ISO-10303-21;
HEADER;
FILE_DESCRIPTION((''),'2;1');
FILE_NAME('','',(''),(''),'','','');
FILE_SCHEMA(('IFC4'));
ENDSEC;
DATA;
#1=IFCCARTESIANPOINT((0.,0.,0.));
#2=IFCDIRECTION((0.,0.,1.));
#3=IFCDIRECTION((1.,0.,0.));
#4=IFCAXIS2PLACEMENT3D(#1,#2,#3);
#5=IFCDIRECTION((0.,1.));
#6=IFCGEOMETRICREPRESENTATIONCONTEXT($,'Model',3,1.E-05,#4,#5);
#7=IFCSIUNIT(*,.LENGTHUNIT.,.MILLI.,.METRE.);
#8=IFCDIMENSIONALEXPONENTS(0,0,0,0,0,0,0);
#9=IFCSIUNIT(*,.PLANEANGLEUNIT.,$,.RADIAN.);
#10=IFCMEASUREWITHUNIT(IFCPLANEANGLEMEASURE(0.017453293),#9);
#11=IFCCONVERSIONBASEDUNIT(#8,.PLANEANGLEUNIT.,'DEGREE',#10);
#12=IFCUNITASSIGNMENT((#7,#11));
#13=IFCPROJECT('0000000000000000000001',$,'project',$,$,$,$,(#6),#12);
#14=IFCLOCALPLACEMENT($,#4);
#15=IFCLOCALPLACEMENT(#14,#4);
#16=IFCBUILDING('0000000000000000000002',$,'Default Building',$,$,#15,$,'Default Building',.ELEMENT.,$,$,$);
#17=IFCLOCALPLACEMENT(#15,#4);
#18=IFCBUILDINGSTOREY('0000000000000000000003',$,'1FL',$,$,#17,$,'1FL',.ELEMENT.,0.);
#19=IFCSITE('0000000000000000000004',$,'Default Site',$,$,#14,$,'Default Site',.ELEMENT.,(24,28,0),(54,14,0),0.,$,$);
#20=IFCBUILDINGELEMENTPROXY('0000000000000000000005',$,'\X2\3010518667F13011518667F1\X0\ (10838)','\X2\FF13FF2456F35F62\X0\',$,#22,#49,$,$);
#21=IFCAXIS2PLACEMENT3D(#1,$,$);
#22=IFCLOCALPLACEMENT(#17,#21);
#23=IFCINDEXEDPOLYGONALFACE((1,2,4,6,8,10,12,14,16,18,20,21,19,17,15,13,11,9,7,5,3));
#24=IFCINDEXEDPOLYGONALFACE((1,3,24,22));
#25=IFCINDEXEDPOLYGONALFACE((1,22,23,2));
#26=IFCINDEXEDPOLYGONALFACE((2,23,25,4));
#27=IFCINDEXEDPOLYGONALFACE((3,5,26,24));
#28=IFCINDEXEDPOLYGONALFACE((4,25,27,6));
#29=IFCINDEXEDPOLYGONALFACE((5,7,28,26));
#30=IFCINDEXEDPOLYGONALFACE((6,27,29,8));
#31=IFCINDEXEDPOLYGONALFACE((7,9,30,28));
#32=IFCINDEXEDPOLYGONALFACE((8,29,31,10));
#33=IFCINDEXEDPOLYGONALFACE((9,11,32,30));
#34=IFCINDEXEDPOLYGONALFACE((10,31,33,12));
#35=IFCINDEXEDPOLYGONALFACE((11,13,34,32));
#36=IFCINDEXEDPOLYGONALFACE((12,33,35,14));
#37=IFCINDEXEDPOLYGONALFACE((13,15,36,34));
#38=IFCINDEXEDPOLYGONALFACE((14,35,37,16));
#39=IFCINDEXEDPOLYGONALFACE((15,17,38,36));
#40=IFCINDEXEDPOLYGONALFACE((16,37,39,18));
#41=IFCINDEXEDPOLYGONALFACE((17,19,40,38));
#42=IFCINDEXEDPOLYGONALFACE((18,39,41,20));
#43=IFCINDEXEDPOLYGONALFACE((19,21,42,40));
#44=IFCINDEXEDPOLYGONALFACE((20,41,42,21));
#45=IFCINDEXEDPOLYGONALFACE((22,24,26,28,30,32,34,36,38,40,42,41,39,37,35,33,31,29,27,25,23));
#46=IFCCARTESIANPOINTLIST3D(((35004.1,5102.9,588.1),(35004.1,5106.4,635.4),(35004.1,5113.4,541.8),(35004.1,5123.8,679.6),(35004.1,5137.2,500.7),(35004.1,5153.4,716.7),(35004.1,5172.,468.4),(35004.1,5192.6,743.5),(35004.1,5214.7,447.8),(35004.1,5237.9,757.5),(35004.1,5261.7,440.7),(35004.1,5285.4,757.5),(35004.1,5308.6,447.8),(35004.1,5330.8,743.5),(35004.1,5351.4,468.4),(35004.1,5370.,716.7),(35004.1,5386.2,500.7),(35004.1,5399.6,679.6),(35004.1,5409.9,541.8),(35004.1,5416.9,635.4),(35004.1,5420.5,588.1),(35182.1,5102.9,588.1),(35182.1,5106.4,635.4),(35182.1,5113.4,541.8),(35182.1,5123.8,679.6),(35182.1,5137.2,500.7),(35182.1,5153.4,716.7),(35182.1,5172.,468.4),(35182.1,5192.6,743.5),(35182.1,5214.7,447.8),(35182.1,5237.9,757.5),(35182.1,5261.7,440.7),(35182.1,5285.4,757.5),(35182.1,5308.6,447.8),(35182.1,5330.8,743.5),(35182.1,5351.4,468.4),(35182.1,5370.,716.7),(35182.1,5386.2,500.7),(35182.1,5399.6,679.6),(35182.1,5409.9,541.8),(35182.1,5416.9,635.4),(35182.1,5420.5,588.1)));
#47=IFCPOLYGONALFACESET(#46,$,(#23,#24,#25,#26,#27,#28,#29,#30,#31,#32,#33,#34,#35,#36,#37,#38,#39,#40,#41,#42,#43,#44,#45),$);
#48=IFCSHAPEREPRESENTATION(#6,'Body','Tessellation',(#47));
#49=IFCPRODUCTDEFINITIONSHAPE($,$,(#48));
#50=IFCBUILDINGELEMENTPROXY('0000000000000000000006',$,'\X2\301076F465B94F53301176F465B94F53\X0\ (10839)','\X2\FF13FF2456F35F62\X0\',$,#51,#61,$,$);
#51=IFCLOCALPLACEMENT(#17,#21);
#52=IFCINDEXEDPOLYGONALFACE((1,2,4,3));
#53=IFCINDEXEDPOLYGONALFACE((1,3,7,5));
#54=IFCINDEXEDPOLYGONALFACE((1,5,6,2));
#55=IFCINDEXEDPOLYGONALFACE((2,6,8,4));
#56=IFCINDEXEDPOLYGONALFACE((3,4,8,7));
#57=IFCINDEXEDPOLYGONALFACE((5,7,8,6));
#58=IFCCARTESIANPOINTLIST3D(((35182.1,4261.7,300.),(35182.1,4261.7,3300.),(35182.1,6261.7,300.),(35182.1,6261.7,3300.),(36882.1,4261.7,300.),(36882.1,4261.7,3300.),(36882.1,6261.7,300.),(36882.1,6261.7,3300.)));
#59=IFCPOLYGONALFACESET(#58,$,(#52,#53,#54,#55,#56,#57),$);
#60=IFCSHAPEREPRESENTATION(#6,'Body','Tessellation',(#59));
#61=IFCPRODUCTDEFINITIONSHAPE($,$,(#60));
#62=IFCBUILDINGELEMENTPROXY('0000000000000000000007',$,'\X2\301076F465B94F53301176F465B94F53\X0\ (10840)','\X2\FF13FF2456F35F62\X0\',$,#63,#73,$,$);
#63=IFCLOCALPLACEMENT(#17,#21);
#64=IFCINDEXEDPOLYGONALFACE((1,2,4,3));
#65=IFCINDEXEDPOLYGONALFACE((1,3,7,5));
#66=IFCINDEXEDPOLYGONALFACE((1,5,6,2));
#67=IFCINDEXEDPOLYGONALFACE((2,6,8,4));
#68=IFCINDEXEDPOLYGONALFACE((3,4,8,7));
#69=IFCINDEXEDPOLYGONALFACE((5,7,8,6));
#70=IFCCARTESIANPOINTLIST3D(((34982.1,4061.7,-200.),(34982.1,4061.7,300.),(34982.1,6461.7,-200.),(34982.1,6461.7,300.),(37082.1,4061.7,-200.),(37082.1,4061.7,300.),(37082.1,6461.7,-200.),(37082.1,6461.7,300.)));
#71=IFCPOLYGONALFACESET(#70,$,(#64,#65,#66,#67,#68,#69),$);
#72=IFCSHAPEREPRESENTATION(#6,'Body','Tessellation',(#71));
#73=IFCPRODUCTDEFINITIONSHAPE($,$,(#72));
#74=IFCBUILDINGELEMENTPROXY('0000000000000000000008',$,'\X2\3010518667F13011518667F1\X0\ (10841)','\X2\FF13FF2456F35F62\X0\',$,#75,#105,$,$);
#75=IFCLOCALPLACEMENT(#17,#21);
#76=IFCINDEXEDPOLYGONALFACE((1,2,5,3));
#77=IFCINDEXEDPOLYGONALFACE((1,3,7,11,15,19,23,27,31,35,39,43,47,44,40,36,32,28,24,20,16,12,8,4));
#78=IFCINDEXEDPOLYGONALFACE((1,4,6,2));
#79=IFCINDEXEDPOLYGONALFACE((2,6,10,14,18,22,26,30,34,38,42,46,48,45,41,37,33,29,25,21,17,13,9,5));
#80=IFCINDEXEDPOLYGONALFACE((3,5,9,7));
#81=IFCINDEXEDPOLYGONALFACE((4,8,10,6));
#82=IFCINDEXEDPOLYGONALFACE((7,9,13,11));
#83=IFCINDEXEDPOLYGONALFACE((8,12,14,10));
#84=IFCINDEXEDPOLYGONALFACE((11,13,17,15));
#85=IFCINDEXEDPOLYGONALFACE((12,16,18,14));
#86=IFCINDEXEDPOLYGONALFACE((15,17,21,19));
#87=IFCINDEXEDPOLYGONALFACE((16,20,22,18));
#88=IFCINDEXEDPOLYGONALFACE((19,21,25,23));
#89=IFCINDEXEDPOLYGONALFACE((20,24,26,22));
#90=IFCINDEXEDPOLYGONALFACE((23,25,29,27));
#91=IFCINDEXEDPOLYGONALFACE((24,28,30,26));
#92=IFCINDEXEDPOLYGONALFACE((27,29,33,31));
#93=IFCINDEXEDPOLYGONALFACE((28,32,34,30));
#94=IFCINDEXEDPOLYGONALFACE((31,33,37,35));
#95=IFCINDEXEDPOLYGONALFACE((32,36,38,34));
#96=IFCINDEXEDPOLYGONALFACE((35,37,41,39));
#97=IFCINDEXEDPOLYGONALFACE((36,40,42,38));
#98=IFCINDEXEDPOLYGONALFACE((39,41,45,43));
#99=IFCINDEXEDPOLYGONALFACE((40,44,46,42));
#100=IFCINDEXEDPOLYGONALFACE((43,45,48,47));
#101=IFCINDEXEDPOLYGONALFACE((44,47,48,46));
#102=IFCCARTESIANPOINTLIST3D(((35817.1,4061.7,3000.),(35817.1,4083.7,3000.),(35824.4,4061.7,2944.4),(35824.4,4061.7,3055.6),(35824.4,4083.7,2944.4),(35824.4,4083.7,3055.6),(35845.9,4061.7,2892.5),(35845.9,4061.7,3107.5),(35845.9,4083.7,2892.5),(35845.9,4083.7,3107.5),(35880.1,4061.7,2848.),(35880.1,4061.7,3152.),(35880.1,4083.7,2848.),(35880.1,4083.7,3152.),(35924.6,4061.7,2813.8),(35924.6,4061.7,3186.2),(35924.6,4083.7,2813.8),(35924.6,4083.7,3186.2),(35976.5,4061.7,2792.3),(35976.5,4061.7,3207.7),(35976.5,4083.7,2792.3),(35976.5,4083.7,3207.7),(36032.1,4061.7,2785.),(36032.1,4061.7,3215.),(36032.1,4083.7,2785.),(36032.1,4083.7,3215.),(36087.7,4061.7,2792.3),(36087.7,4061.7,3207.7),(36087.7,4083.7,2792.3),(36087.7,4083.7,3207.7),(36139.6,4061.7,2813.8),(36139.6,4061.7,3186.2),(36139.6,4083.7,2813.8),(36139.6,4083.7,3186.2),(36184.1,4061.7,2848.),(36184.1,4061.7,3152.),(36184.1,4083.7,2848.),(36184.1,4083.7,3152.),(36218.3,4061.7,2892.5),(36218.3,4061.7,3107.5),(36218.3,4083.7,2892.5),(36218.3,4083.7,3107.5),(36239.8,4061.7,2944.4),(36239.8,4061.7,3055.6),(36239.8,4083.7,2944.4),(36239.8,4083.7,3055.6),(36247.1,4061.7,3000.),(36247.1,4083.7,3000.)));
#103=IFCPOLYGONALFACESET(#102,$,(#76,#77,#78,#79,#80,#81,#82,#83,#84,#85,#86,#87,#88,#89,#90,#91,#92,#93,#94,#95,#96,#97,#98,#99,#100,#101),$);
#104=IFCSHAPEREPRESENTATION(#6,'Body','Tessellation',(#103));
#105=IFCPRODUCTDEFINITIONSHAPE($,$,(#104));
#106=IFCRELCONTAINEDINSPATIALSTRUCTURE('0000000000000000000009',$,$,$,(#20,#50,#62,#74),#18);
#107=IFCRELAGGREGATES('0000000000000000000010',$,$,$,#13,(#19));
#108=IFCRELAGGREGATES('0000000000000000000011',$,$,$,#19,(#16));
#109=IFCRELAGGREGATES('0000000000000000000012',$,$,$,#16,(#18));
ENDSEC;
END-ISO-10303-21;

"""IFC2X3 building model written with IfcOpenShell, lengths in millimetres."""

from ifc_helpers import new_model, entity, si_unit, converted_unit, direction, frame, origin_with_axes, origin_2d_with_axis, place, context, project, spatial, rectangle, circle, extrude, source, transform, mapped, element, save


model = new_model("IFC2X3")

# Units and contexts
model_context = context("Model", 3, precision=1e-05, world=origin_with_axes(), true_north=direction((0.0, 1.0)))
ifc_project = project(units=[si_unit("LENGTHUNIT", "METRE", prefix="MILLI"), converted_unit("PLANEANGLEUNIT", "DEGREE", entity("IfcPlaneAngleMeasure", 0.017453293), si_unit("PLANEANGLEUNIT", "RADIAN"), dimensions=[0, 0, 0, 0, 0, 0, 0])], contexts=[model_context])

# Site, building, storey
site_placement = place(None, origin_with_axes())
site = spatial("IfcSite", under=ifc_project, at=site_placement, Name="Default Site", LongName="Default Site", CompositionType="ELEMENT", RefLatitude=(24, 28, 0), RefLongitude=(54, 14, 0), RefElevation=0.0)
building_placement = place(site_placement, origin_with_axes())
building = spatial("IfcBuilding", under=site, at=building_placement, Name="Default Building", LongName="Default Building", CompositionType="ELEMENT")
storey_placement = place(building_placement, origin_with_axes())
storey = spatial("IfcBuildingStorey", under=building, at=storey_placement, Name="1FL", LongName="1FL", CompositionType="ELEMENT", Elevation=0.0)

# Building element proxies
shared_shape_1 = source(origin_with_axes(), model_context, "Body", "SweptSolid", [
    extrude(circle(Radius=159.2, at=origin_2d_with_axis()), frame((0.0, 0.0, 0.0), z_axis=(0.0, 0.0, 1.0), x_axis=(1.0, 0.0, 0.0)), (0.0, 0.0, 1.0), 178.0),
])
proxy_1_placement = place(storey_placement, frame((35182.1, 5261.7, 600.0), z_axis=(-1.0, 0.0, 0.0), x_axis=(0.0, 0.0, -1.0)))
element("IfcBuildingElementProxy", 1, at=proxy_1_placement, inside=storey, Name="【円柱】円柱 (10838)", Description="３Ｄ図形", context=model_context, shape_type="MappedRepresentation", body=[
    mapped(shared_shape_1, transform((0.0, 0.0, 0.0))),
])
shared_shape_2 = source(origin_with_axes(), model_context, "Body", "SweptSolid", [
    extrude(rectangle(XDim=2000.0, YDim=1700.0, at=origin_2d_with_axis()), frame((0.0, 0.0, 0.0), z_axis=(0.0, 0.0, 1.0), x_axis=(1.0, 0.0, 0.0)), (0.0, 0.0, 1.0), 3000.0),
])
proxy_2_placement = place(storey_placement, frame((36032.1, 5261.7, 300.0), z_axis=(0.0, 0.0, 1.0), x_axis=(0.0, 1.0, 0.0)))
element("IfcBuildingElementProxy", 2, at=proxy_2_placement, inside=storey, Name="【直方体】直方体 (10839)", Description="３Ｄ図形", context=model_context, shape_type="MappedRepresentation", body=[
    mapped(shared_shape_2, transform((0.0, 0.0, 0.0))),
])
shared_shape_3 = source(origin_with_axes(), model_context, "Body", "SweptSolid", [
    extrude(rectangle(XDim=2400.0, YDim=2100.0, at=origin_2d_with_axis()), frame((0.0, 0.0, 0.0), z_axis=(0.0, 0.0, 1.0), x_axis=(1.0, 0.0, 0.0)), (0.0, 0.0, 1.0), 500.0),
])
proxy_3_placement = place(storey_placement, frame((36032.1, 5261.7, -200.0), z_axis=(0.0, 0.0, 1.0), x_axis=(0.0, 1.0, 0.0)))
element("IfcBuildingElementProxy", 3, at=proxy_3_placement, inside=storey, Name="【直方体】直方体 (10840)", Description="３Ｄ図形", context=model_context, shape_type="MappedRepresentation", body=[
    mapped(shared_shape_3, transform((0.0, 0.0, 0.0))),
])
shared_shape_4 = source(origin_with_axes(), model_context, "Body", "SweptSolid", [
    extrude(circle(Radius=215.0, at=origin_2d_with_axis()), frame((0.0, 0.0, 0.0), z_axis=(0.0, 0.0, 1.0), x_axis=(1.0, 0.0, 0.0)), (0.0, 0.0, 1.0), 22.0),
])
proxy_4_placement = place(storey_placement, frame((36032.1, 4061.7, 3000.0), z_axis=(0.0, 1.0, 0.0), x_axis=(0.0, 0.0, -1.0)))
element("IfcBuildingElementProxy", 4, at=proxy_4_placement, inside=storey, Name="【円柱】円柱 (10841)", Description="３Ｄ図形", context=model_context, shape_type="MappedRepresentation", body=[
    mapped(shared_shape_4, transform((0.0, 0.0, 0.0))),
])

save(model, "model.ifc")
